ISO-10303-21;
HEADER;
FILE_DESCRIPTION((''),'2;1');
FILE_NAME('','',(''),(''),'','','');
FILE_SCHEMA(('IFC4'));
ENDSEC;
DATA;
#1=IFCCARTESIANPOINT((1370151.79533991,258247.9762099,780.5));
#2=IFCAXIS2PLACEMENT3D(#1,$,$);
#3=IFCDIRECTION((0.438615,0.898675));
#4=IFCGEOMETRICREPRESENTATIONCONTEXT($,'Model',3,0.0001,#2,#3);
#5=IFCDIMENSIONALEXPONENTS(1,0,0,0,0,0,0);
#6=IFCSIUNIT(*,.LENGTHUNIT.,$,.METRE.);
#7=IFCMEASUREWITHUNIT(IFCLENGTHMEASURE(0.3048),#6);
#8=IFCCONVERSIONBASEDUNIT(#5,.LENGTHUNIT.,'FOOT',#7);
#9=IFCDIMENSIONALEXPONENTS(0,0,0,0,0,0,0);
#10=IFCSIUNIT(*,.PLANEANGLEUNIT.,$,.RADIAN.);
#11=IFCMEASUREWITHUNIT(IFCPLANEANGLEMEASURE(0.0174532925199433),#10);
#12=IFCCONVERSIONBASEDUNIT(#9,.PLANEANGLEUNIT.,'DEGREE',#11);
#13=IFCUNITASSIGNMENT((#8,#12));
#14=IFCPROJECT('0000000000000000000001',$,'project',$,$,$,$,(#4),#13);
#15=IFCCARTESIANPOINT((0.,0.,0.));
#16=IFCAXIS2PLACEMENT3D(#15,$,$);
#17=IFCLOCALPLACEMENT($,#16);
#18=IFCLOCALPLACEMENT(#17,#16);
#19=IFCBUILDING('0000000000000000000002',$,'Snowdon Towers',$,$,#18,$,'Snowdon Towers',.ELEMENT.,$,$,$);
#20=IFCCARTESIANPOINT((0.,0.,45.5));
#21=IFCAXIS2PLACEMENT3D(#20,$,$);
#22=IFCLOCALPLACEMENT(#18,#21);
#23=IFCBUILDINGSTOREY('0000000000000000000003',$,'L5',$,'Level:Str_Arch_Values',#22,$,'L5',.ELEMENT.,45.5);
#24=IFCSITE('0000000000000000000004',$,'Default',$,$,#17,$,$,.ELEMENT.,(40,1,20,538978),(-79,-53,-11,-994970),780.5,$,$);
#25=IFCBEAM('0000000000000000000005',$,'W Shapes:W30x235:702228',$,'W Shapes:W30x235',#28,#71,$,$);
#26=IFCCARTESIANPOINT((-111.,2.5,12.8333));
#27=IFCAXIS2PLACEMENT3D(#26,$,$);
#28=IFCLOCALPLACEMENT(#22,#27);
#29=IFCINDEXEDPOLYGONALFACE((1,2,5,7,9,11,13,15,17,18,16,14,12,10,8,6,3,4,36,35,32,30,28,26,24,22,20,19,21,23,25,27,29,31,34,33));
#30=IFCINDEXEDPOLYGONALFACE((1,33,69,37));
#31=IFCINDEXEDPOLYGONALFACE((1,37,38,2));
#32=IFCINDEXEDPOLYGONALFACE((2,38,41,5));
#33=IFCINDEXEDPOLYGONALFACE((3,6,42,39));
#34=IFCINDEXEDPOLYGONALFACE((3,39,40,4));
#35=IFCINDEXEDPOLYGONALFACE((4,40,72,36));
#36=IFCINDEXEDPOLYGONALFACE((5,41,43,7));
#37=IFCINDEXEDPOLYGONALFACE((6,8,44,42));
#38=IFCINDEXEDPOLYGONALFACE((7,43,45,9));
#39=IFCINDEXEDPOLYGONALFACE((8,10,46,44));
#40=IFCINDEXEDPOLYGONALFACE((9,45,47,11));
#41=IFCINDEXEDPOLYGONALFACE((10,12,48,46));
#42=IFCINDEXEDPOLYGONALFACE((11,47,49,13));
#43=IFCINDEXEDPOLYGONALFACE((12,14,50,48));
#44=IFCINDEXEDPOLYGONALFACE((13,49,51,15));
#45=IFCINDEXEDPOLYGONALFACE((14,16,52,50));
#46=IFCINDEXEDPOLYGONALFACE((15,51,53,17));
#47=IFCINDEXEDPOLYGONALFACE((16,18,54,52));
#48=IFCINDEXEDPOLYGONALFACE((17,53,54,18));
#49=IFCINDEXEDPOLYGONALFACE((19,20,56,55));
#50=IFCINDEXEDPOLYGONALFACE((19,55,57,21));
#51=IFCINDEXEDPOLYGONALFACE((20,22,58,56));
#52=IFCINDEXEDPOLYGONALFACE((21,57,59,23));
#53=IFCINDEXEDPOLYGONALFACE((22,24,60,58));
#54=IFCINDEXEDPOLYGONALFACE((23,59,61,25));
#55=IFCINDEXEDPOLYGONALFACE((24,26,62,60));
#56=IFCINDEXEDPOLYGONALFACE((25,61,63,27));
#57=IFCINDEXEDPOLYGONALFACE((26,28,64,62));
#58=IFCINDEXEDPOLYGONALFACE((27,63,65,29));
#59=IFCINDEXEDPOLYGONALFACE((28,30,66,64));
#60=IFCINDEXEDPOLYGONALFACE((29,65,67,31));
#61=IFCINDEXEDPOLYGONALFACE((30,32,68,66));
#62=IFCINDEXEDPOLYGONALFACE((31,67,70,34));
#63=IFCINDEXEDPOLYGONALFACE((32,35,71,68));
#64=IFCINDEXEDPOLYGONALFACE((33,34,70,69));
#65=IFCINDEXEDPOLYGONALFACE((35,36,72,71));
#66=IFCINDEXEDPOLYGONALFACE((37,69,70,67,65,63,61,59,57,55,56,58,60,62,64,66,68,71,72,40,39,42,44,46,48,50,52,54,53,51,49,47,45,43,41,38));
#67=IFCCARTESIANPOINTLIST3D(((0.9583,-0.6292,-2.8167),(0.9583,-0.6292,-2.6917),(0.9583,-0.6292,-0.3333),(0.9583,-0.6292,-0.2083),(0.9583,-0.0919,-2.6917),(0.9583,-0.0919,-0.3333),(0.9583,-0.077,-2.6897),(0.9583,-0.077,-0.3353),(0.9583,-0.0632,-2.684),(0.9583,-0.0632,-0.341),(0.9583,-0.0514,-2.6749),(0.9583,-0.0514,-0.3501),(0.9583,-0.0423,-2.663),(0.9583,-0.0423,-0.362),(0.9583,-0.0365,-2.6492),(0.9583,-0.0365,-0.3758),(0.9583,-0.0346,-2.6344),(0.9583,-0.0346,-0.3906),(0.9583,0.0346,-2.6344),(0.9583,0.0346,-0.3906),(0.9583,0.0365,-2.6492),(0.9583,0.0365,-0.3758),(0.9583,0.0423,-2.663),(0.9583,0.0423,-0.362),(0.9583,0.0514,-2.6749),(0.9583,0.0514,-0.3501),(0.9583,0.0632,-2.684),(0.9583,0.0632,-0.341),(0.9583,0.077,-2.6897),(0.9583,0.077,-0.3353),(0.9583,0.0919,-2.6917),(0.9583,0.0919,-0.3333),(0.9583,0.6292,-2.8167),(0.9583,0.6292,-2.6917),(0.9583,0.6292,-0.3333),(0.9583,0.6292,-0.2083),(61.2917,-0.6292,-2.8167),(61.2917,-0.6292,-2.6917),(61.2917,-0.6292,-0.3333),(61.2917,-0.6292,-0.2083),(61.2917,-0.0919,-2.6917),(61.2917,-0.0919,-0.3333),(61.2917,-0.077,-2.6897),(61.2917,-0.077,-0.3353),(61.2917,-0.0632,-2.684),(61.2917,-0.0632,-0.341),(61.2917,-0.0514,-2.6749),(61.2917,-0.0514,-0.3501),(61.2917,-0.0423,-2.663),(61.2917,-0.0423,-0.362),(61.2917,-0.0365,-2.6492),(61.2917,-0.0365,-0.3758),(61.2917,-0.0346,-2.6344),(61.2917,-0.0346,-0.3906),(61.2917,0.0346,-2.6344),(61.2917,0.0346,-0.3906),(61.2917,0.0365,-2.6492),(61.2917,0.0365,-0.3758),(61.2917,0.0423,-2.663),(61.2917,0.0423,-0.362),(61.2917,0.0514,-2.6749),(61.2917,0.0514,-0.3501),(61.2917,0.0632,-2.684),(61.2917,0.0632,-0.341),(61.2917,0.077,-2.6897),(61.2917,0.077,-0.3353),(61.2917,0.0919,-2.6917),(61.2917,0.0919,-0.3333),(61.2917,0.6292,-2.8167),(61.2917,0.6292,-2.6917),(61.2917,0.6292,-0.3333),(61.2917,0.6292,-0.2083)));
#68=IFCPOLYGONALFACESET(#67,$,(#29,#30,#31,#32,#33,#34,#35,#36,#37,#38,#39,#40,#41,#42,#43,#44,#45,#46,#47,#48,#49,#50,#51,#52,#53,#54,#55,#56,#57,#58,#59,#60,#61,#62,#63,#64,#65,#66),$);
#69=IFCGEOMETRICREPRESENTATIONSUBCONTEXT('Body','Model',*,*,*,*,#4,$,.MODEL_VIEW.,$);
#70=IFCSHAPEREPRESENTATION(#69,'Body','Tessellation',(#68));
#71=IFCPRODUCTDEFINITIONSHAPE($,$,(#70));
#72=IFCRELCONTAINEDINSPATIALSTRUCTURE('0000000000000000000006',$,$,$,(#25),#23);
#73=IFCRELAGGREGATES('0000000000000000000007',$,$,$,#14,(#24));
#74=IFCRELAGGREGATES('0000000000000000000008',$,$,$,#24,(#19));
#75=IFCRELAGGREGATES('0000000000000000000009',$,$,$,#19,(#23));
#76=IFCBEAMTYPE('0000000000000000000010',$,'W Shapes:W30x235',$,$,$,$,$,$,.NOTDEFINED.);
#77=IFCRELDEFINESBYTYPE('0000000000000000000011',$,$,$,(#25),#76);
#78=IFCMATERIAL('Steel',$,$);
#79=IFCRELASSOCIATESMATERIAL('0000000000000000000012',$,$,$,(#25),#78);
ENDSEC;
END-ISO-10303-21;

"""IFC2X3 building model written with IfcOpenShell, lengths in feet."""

from ifc_helpers import new_model, entity, si_unit, converted_unit, direction, frame, frame_2d, origin, place, context, subcontext, project, spatial, i_section, extrude, material, type_object, element, save


model = new_model("IFC2X3")

# Units and contexts
model_context = context("Model", 3, precision=0.0001, world=frame((1370151.79533991, 258247.9762099, 780.5)), true_north=direction((0.438615, 0.898675)))
body_context = subcontext(model_context, "Body", "Model", "MODEL_VIEW")
ifc_project = project(units=[converted_unit("LENGTHUNIT", "FOOT", entity("IfcLengthMeasure", 0.3048), si_unit("LENGTHUNIT", "METRE"), dimensions=[1, 0, 0, 0, 0, 0, 0]), converted_unit("PLANEANGLEUNIT", "DEGREE", entity("IfcPlaneAngleMeasure", 0.0174532925199433), si_unit("PLANEANGLEUNIT", "RADIAN"), dimensions=[0, 0, 0, 0, 0, 0, 0])], contexts=[model_context])

# Site, building, storey
site_placement = place(None, origin())
site = spatial("IfcSite", under=ifc_project, at=site_placement, Name="Default", CompositionType="ELEMENT", RefLatitude=(40, 1, 20, 538978), RefLongitude=(-79, -53, -11, -994970), RefElevation=780.5)
building_placement = place(site_placement, origin())
building = spatial("IfcBuilding", under=site, at=building_placement, Name="Snowdon Towers", LongName="Snowdon Towers", CompositionType="ELEMENT")
storey_placement = place(building_placement, frame((0.0, 0.0, 45.5)))
storey = spatial("IfcBuildingStorey", under=building, at=storey_placement, Name="L5", ObjectType="Level:Str_Arch_Values", LongName="L5", CompositionType="ELEMENT", Elevation=45.5)

# Shared definitions
ifc_material = material(Name="Steel")

# Beam
beam_type_1 = type_object("IfcBeamType", Name="W Shapes:W30x235", PredefinedType="NOTDEFINED")
beam_1_placement = place(storey_placement, frame((-111.0, 2.5, 12.8333)))
element("IfcBeam", 1, at=beam_1_placement, inside=storey, type_object=beam_type_1, material=ifc_material, Name="W Shapes:W30x235:702228", ObjectType="W Shapes:W30x235", context=body_context, shape_type="SweptSolid", body=[
    extrude(i_section(OverallWidth=1.2583, OverallDepth=2.6083, WebThickness=0.0692, FlangeThickness=0.125, FilletRadius=0.0573, at=frame_2d((0.0, 0.0), x_axis=(0.0, 1.0))), frame((0.9583, 0.0, -1.5125), z_axis=(1.0, 0.0, 0.0), x_axis=(0.0, 0.0, -1.0)), (0.0, 0.0, 1.0), 60.3333),
])

save(model, "model.ifc")
